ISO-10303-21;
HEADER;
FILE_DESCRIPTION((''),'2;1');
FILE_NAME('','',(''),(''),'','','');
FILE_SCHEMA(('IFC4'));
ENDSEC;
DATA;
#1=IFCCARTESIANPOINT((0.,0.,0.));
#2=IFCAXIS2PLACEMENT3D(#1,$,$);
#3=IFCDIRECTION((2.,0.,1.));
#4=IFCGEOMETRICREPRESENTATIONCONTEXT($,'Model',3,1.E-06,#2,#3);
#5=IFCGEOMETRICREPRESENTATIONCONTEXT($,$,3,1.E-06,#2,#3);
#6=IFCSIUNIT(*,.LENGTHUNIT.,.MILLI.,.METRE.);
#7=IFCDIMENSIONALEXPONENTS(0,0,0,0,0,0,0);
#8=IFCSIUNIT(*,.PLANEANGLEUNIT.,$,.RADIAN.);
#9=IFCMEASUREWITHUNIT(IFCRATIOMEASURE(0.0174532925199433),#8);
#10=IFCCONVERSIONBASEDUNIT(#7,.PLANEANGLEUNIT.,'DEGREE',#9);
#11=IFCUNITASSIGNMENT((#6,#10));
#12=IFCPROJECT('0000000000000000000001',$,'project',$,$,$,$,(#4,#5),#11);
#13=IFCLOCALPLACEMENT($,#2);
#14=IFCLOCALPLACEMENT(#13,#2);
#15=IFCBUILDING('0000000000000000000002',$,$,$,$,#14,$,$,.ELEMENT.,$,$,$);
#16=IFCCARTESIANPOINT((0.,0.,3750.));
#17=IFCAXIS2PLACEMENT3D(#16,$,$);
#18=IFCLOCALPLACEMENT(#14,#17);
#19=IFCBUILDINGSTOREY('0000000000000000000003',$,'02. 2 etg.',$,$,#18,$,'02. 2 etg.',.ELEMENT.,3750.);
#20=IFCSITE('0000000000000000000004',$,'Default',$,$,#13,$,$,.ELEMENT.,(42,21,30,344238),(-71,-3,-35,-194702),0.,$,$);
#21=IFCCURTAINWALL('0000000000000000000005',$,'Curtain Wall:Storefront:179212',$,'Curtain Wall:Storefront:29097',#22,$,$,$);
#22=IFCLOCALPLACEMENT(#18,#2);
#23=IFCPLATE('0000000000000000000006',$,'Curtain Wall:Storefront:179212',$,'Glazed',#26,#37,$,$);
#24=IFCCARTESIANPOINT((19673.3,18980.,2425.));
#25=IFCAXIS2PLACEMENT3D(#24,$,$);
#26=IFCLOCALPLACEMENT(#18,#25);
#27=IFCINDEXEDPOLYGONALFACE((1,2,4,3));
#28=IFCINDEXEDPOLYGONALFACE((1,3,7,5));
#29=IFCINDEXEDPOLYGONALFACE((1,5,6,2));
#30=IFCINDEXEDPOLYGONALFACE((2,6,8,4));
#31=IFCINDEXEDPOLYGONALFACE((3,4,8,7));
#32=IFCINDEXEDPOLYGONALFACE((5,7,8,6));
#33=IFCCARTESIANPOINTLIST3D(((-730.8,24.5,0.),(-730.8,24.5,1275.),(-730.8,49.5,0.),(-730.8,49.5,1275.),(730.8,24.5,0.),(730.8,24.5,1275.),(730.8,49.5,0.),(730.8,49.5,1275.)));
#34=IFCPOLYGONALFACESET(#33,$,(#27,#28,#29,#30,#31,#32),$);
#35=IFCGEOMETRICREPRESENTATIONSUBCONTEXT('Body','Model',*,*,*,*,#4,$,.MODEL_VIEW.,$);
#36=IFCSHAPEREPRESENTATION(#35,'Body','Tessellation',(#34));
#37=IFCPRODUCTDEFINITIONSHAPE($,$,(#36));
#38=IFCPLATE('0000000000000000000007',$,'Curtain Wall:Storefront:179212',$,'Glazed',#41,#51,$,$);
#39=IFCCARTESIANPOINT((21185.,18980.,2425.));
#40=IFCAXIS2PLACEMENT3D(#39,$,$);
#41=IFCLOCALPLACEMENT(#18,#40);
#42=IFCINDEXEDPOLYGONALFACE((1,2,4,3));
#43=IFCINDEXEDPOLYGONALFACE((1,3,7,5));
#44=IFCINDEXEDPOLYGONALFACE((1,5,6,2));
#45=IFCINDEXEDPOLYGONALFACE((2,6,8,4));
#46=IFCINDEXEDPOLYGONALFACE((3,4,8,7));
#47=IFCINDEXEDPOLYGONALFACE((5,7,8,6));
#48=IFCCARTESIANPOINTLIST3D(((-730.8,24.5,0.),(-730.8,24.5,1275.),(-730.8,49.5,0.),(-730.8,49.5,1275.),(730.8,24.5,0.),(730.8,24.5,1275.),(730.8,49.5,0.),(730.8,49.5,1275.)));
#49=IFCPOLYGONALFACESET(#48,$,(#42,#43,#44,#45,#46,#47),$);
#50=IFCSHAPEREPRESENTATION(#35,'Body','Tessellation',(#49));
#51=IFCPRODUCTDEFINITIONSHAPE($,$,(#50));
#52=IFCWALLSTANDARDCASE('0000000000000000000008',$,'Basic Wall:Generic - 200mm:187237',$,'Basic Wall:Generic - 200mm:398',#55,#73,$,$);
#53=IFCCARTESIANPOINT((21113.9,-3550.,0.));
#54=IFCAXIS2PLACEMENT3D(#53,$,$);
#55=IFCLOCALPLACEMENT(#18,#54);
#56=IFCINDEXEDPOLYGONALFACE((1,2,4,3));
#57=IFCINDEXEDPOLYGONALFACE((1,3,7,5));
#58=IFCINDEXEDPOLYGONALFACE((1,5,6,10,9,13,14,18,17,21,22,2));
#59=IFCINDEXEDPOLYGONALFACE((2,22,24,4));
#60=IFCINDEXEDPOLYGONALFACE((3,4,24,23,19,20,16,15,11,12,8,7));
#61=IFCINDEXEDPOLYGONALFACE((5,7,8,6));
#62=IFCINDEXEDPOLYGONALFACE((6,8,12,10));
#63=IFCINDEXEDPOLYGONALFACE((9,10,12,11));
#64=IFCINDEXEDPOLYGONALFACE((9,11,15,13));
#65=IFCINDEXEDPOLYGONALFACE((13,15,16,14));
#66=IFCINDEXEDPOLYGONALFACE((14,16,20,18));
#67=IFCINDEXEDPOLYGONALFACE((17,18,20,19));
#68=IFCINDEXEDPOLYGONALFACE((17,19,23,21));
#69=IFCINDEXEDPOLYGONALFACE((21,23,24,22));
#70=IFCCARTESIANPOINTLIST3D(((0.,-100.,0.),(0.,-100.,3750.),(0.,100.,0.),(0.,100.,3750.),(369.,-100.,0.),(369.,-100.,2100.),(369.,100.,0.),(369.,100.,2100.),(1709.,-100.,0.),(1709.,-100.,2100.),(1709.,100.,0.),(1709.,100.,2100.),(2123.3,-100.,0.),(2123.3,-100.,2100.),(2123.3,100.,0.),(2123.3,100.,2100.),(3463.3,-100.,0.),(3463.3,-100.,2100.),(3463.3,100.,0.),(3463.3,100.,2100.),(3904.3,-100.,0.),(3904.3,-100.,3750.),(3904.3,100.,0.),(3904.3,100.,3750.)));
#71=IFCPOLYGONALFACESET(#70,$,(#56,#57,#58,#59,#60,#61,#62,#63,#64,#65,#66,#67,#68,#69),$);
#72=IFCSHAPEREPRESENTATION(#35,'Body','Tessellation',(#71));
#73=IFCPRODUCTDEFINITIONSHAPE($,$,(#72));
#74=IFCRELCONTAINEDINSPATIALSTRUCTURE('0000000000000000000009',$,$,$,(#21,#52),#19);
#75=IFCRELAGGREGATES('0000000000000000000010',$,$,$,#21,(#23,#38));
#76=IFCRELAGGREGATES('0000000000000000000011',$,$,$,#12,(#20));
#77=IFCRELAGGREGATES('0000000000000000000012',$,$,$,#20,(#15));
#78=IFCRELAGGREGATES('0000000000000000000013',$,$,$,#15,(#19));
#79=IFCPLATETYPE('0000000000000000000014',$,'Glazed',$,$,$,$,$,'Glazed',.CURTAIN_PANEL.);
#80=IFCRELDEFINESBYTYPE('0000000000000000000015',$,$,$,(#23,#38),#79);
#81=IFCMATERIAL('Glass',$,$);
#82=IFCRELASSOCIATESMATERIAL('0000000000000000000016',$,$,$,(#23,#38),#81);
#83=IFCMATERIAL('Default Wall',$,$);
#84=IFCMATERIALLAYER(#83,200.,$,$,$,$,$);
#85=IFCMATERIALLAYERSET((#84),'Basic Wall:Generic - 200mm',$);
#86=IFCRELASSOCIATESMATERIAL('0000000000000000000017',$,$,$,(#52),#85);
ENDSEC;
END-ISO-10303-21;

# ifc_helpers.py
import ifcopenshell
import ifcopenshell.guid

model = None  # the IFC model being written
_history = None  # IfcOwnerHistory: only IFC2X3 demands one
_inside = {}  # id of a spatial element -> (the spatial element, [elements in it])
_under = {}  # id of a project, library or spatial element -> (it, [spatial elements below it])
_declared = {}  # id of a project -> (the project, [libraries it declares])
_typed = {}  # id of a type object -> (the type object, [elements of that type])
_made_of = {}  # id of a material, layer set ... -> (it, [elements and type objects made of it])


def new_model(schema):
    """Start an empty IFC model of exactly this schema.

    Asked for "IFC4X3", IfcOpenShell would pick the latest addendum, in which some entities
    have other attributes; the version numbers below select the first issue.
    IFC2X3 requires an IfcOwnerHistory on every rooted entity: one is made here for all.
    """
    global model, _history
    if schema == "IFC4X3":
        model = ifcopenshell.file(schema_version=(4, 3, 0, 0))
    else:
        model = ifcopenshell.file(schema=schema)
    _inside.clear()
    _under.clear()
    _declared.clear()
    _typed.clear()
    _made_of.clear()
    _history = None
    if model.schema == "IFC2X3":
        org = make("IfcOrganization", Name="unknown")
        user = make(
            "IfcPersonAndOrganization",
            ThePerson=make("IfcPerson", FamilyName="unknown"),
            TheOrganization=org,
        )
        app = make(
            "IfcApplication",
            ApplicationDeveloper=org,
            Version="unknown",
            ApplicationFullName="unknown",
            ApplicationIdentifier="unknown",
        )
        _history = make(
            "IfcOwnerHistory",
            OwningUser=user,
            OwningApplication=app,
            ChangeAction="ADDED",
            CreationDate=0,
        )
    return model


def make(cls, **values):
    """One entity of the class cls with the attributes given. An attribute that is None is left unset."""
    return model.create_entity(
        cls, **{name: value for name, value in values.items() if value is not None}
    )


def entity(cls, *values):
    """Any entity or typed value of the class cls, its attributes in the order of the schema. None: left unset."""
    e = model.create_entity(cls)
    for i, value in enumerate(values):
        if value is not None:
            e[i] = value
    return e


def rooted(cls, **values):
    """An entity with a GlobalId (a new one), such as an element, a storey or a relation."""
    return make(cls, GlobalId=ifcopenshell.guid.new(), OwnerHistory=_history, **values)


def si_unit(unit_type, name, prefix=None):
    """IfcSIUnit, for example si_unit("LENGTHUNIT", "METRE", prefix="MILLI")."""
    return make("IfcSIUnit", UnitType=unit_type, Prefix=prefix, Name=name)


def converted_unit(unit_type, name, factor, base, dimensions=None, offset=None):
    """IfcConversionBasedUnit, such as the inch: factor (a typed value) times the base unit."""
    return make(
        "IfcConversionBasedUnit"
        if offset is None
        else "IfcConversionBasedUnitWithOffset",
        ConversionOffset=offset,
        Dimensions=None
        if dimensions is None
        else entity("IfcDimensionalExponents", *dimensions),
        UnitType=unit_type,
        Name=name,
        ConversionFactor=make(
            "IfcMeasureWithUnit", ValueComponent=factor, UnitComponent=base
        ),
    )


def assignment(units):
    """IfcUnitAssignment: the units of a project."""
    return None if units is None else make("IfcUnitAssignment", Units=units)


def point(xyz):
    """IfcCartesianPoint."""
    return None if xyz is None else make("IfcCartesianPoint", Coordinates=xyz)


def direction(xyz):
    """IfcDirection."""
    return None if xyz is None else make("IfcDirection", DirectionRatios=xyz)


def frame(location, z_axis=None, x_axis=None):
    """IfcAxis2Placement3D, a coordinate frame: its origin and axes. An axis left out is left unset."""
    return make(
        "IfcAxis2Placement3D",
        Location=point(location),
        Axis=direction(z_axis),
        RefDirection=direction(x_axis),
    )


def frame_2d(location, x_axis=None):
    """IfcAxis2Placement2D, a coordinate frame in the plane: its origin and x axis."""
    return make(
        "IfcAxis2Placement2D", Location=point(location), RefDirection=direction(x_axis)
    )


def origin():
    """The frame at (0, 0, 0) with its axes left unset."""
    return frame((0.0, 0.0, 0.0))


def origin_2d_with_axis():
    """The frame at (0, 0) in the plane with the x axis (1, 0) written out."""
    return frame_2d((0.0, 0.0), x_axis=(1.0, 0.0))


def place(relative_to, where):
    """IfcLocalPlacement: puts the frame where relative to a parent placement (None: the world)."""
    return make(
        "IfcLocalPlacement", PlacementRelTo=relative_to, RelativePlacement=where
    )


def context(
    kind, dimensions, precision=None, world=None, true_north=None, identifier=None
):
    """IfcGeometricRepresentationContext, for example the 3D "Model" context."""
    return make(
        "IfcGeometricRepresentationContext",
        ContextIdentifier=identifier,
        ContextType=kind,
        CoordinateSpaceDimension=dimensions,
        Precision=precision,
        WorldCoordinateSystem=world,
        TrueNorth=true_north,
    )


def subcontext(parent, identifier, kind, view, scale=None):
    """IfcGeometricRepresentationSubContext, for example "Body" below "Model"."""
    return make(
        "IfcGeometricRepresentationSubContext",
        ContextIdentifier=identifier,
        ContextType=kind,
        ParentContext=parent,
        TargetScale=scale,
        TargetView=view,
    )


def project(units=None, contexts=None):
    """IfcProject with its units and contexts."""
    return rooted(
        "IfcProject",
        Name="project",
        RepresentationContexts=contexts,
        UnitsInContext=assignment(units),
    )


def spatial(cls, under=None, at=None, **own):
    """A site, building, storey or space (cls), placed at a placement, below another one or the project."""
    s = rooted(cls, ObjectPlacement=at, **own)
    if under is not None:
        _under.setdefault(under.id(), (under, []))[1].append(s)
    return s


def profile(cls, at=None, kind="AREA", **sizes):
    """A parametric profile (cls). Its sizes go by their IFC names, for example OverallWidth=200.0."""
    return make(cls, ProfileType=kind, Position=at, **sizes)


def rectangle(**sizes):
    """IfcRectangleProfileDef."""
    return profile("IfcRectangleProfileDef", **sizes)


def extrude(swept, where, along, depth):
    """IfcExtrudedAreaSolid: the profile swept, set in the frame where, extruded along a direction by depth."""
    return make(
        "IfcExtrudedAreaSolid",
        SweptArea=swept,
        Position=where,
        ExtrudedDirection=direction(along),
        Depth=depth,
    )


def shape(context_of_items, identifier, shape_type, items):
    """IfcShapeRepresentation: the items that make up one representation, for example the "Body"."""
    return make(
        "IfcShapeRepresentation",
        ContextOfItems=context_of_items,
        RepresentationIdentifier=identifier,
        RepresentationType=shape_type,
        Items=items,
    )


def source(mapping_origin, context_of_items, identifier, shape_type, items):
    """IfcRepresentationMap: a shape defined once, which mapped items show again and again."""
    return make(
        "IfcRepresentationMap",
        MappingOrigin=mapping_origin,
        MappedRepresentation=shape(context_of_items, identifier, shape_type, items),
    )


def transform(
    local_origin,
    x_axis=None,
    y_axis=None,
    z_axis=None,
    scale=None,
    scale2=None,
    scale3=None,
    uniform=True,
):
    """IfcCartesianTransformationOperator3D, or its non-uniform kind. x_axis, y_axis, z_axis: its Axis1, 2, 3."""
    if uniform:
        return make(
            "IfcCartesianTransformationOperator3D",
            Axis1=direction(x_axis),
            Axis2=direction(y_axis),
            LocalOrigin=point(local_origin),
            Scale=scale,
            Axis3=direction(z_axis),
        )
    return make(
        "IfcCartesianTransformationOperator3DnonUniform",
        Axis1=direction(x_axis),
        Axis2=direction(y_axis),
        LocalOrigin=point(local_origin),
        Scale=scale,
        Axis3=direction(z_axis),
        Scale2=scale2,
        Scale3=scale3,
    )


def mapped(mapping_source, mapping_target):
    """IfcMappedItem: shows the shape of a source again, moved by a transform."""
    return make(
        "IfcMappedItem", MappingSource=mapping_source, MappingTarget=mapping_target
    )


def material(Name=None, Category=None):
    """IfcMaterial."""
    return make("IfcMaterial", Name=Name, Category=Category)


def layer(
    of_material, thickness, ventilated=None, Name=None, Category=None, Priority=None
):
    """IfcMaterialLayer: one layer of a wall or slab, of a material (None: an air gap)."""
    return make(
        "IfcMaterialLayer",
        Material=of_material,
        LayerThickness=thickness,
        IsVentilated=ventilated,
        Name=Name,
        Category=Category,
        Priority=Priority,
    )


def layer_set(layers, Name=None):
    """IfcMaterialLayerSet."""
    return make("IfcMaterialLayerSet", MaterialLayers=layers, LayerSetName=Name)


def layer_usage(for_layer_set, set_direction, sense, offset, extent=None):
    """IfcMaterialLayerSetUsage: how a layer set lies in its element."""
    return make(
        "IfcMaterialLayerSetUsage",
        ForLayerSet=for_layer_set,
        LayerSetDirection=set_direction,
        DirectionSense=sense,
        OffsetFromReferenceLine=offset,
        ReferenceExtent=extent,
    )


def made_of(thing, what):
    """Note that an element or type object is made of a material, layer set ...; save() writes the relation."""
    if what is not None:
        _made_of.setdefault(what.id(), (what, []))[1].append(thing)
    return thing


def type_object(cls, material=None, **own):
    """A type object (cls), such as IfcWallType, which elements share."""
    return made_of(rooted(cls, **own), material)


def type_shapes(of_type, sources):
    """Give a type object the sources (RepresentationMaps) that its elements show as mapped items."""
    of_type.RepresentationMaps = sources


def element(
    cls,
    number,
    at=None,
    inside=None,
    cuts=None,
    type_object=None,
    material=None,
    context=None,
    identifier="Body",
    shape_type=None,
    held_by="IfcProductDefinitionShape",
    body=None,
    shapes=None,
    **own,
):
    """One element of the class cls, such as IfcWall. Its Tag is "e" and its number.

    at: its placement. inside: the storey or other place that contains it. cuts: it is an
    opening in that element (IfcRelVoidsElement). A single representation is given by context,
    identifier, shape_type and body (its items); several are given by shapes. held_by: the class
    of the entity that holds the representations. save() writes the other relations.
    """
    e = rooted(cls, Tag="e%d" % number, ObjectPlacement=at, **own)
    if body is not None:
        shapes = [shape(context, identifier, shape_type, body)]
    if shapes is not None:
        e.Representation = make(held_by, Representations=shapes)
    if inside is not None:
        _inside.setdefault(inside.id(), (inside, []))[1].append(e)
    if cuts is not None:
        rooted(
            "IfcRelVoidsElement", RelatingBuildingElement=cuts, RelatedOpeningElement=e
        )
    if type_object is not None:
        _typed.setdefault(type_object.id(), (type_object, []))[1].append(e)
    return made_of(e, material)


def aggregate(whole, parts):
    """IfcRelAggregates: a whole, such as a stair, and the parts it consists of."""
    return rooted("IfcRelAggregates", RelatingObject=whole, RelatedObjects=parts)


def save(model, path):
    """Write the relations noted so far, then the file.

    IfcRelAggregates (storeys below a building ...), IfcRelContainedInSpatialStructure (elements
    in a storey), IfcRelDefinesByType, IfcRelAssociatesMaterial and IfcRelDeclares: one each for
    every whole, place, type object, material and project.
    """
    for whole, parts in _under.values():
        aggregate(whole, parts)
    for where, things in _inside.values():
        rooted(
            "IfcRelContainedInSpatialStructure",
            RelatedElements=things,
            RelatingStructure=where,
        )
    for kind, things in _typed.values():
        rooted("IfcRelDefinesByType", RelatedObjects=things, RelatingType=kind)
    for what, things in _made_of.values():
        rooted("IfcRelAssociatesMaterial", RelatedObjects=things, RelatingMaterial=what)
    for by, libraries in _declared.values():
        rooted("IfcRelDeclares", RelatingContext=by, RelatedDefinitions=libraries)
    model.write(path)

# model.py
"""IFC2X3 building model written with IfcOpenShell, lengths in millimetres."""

from ifc_helpers import new_model, entity, si_unit, converted_unit, direction, frame, frame_2d, origin, origin_2d_with_axis, place, context, subcontext, project, spatial, rectangle, extrude, source, transform, mapped, material, layer, layer_set, layer_usage, type_object, type_shapes, element, aggregate, save


model = new_model("IFC2X3")

# Units and contexts
model_context = context("Model", 3, precision=1e-06, world=origin(), true_north=direction((2.0, 0.0, 1.0)))
context_of_model = context(None, 3, precision=1e-06, world=origin(), true_north=direction((2.0, 0.0, 1.0)))
body_context = subcontext(model_context, "Body", "Model", "MODEL_VIEW")
ifc_project = project(units=[si_unit("LENGTHUNIT", "METRE", prefix="MILLI"), converted_unit("PLANEANGLEUNIT", "DEGREE", entity("IfcRatioMeasure", 0.0174532925199433), si_unit("PLANEANGLEUNIT", "RADIAN"), dimensions=[0, 0, 0, 0, 0, 0, 0])], contexts=[model_context, context_of_model])

# Site, building, storey
site_placement = place(None, origin())
site = spatial("IfcSite", under=ifc_project, at=site_placement, Name="Default", CompositionType="ELEMENT", RefLatitude=(42, 21, 30, 344238), RefLongitude=(-71, -3, -35, -194702), RefElevation=0.0)
building_placement = place(site_placement, origin())
building = spatial("IfcBuilding", under=site, at=building_placement, CompositionType="ELEMENT")
storey_placement = place(building_placement, frame((0.0, 0.0, 3750.0)))
storey = spatial("IfcBuildingStorey", under=building, at=storey_placement, Name="02. 2 etg.", LongName="02. 2 etg.", CompositionType="ELEMENT", Elevation=3750.0)

# Curtain wall, plates
curtain_wall_placement = place(storey_placement, origin())
curtain_wall = element("IfcCurtainWall", 1, at=curtain_wall_placement, inside=storey, Name="Curtain Wall:Storefront:179212", ObjectType="Curtain Wall:Storefront:29097")
ifc_material_1 = material(Name="Glass")
plate_type_1 = type_object("IfcPlateType", Name="Glazed", ElementType="Glazed", PredefinedType="CURTAIN_PANEL")
shared_shape_1 = source(origin(), body_context, "Body", "SweptSolid", [
    extrude(rectangle(XDim=25.0, YDim=1461.7, at=origin_2d_with_axis()), frame((0.0, 37.0, 0.0), z_axis=(0.0, 0.0, 1.0), x_axis=(0.0, 1.0, 0.0)), (0.0, 0.0, 1.0), 1275.0),
])
type_shapes(plate_type_1, [shared_shape_1])
plate_1_placement = place(storey_placement, frame((19673.3, 18980.0, 2425.0)))
plate_1 = element("IfcPlate", 2, at=plate_1_placement, type_object=plate_type_1, material=ifc_material_1, Name="Curtain Wall:Storefront:179212", ObjectType="Glazed", context=body_context, shape_type="MappedRepresentation", body=[
    mapped(shared_shape_1, transform((0.0, 0.0, 0.0), scale=1.0)),
])
plate_2_placement = place(storey_placement, frame((21185.0, 18980.0, 2425.0)))
plate_2 = element("IfcPlate", 3, at=plate_2_placement, type_object=plate_type_1, material=ifc_material_1, Name="Curtain Wall:Storefront:179212", ObjectType="Glazed", context=body_context, shape_type="MappedRepresentation", body=[
    mapped(shared_shape_1, transform((0.0, 0.0, 0.0), scale=1.0)),
])
aggregate(curtain_wall, [plate_1, plate_2])

# Shared definitions
ifc_material_2 = material(Name="Default Wall")
ifc_layer_1 = layer(ifc_material_2, 200.0)
ifc_layer_set_1 = layer_set([ifc_layer_1], Name="Basic Wall:Generic - 200mm")

# Wall, openings
ifc_layer_usage_1 = layer_usage(ifc_layer_set_1, "AXIS2", "NEGATIVE", 100.0)
wall_1_placement = place(storey_placement, frame((21113.9, -3550.0, 0.0)))
wall_1 = element("IfcWallStandardCase", 4, at=wall_1_placement, inside=storey, material=ifc_layer_usage_1, Name="Basic Wall:Generic - 200mm:187237", ObjectType="Basic Wall:Generic - 200mm:398", context=body_context, shape_type="SweptSolid", body=[
    extrude(rectangle(XDim=3904.3, YDim=200.0, at=frame_2d((1952.2, 0.0), x_axis=(-1.0, 0.0))), origin(), (0.0, 0.0, 1.0), 3750.0),
])
opening_1_placement = place(wall_1_placement, origin())
element("IfcOpeningElement", 5, at=opening_1_placement, cuts=wall_1, ObjectType="Opening", context=body_context, shape_type="SweptSolid", body=[
    extrude(rectangle(XDim=2100.0, YDim=1340.0, at=origin_2d_with_axis()), frame((2793.3, -1624.0, 1050.0), z_axis=(0.0, 1.0, 0.0), x_axis=(0.0, 0.0, -1.0)), (0.0, 0.0, 1.0), 3048.0),
])
opening_2_placement = place(wall_1_placement, origin())
element("IfcOpeningElement", 6, at=opening_2_placement, cuts=wall_1, ObjectType="Opening", context=body_context, shape_type="SweptSolid", body=[
    extrude(rectangle(XDim=2100.0, YDim=1340.0, at=origin_2d_with_axis()), frame((1039.0, -1624.0, 1050.0), z_axis=(0.0, 1.0, 0.0), x_axis=(0.0, 0.0, -1.0)), (0.0, 0.0, 1.0), 3048.0),
])

save(model, "model.ifc")
